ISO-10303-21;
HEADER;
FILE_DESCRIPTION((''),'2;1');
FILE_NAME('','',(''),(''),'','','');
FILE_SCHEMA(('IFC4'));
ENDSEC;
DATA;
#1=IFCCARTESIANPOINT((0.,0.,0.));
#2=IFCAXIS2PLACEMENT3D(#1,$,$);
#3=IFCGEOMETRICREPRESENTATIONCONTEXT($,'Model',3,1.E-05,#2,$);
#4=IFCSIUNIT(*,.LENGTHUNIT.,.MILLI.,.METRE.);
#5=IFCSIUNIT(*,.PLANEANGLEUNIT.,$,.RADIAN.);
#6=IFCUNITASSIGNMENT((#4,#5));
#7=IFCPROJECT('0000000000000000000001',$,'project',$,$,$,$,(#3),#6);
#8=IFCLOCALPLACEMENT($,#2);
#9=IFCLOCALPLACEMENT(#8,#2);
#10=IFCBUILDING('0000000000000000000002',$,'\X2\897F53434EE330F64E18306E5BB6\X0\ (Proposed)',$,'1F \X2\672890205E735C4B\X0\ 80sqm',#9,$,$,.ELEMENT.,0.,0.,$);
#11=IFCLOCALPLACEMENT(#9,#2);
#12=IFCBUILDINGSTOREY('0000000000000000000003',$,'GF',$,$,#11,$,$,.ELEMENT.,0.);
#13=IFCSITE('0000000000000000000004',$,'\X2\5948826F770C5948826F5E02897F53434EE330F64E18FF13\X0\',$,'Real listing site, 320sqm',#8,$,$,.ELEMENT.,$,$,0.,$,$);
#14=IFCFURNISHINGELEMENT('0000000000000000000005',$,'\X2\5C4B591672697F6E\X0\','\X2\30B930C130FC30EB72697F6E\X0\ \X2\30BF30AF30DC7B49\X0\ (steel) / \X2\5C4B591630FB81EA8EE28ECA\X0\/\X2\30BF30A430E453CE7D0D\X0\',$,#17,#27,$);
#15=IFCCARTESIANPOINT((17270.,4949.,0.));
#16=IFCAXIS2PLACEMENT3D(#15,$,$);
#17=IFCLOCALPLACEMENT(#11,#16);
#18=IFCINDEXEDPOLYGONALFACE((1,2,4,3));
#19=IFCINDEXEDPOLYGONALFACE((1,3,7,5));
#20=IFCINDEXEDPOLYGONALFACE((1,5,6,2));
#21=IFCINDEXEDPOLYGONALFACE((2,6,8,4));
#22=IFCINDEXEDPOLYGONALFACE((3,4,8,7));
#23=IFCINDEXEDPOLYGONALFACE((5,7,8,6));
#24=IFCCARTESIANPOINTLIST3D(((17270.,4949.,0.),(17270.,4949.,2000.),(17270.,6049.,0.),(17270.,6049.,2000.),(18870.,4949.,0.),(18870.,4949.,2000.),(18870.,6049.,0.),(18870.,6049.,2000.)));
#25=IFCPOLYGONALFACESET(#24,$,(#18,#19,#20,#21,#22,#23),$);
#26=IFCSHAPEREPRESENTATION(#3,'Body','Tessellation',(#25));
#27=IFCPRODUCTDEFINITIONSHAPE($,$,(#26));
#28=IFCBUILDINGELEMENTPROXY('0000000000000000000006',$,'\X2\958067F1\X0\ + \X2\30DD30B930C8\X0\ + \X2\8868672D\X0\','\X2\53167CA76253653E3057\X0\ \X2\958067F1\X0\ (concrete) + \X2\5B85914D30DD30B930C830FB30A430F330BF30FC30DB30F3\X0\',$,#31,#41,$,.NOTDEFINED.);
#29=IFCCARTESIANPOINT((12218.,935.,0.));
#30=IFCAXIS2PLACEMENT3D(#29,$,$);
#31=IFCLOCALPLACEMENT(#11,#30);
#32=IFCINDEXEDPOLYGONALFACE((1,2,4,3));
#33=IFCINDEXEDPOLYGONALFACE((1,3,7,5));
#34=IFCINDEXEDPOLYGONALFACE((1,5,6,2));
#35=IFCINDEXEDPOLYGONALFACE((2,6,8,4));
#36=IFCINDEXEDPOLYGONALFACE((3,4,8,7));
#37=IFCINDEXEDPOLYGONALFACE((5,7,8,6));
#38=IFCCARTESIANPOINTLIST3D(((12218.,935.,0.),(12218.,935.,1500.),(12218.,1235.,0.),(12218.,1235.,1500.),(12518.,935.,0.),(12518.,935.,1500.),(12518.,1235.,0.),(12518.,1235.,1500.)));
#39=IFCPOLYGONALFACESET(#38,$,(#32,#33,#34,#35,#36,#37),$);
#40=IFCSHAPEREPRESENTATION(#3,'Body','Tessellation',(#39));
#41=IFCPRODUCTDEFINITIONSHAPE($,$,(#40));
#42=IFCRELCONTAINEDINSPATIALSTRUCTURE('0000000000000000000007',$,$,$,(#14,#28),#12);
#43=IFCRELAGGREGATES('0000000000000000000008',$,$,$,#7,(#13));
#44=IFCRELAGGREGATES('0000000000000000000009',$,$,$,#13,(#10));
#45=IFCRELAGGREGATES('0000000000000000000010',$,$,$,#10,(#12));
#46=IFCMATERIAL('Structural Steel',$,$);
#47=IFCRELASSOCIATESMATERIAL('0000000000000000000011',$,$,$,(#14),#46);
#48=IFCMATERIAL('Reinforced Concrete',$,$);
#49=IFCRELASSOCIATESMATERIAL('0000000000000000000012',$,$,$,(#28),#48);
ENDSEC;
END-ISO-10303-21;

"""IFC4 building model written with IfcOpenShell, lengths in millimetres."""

from ifc_helpers import new_model, si_unit, frame, frame_2d, origin, place, context, project, spatial, rectangle, extrude, material, element, save


model = new_model("IFC4")

# Units and contexts
model_context = context("Model", 3, precision=1e-05, world=origin())
ifc_project = project(units=[si_unit("LENGTHUNIT", "METRE", prefix="MILLI"), si_unit("PLANEANGLEUNIT", "RADIAN")], contexts=[model_context])

# Site, building, storey
site_placement = place(None, origin())
site = spatial("IfcSite", under=ifc_project, at=site_placement, Name="奈良県奈良市西千代ヶ丘３", ObjectType="Real listing site, 320sqm", CompositionType="ELEMENT", RefElevation=0.0)
building_placement = place(site_placement, origin())
building = spatial("IfcBuilding", under=site, at=building_placement, Name="西千代ヶ丘の家 (Proposed)", ObjectType="1F 木造平屋 80sqm", CompositionType="ELEMENT", ElevationOfRefHeight=0.0, ElevationOfTerrain=0.0)
storey_placement = place(building_placement, origin())
storey = spatial("IfcBuildingStorey", under=building, at=storey_placement, Name="GF", CompositionType="ELEMENT", Elevation=0.0)

# Shared definitions
ifc_material_1 = material(Name="Reinforced Concrete")

# Shared definitions
ifc_material_2 = material(Name="Structural Steel")

# Furnishing element
furnishing_1_placement = place(storey_placement, frame((17270.0, 4949.0, 0.0)))
element("IfcFurnishingElement", 1, at=furnishing_1_placement, inside=storey, material=ifc_material_2, Name="屋外物置", Description="スチール物置 タクボ等 (steel) / 屋外・自転車/タイヤ収納", context=model_context, shape_type="SweptSolid", body=[
    extrude(rectangle(XDim=1600.0, YDim=1100.0, at=frame_2d((800.0, 550.0))), frame((17270.0, 4949.0, 0.0)), (0.0, 0.0, 1.0), 2000.0),
])

# Building element proxy
proxy_placement = place(storey_placement, frame((12218.0, 935.0, 0.0)))
element("IfcBuildingElementProxy", 2, at=proxy_placement, inside=storey, material=ifc_material_1, Name="門柱 + ポスト + 表札", Description="化粧打放し 門柱 (concrete) + 宅配ポスト・インターホン", PredefinedType="NOTDEFINED", context=model_context, shape_type="SweptSolid", body=[
    extrude(rectangle(XDim=300.0, YDim=300.0, at=frame_2d((150.0, 150.0))), frame((12218.0, 935.0, 0.0)), (0.0, 0.0, 1.0), 1500.0),
])

save(model, "model.ifc")
